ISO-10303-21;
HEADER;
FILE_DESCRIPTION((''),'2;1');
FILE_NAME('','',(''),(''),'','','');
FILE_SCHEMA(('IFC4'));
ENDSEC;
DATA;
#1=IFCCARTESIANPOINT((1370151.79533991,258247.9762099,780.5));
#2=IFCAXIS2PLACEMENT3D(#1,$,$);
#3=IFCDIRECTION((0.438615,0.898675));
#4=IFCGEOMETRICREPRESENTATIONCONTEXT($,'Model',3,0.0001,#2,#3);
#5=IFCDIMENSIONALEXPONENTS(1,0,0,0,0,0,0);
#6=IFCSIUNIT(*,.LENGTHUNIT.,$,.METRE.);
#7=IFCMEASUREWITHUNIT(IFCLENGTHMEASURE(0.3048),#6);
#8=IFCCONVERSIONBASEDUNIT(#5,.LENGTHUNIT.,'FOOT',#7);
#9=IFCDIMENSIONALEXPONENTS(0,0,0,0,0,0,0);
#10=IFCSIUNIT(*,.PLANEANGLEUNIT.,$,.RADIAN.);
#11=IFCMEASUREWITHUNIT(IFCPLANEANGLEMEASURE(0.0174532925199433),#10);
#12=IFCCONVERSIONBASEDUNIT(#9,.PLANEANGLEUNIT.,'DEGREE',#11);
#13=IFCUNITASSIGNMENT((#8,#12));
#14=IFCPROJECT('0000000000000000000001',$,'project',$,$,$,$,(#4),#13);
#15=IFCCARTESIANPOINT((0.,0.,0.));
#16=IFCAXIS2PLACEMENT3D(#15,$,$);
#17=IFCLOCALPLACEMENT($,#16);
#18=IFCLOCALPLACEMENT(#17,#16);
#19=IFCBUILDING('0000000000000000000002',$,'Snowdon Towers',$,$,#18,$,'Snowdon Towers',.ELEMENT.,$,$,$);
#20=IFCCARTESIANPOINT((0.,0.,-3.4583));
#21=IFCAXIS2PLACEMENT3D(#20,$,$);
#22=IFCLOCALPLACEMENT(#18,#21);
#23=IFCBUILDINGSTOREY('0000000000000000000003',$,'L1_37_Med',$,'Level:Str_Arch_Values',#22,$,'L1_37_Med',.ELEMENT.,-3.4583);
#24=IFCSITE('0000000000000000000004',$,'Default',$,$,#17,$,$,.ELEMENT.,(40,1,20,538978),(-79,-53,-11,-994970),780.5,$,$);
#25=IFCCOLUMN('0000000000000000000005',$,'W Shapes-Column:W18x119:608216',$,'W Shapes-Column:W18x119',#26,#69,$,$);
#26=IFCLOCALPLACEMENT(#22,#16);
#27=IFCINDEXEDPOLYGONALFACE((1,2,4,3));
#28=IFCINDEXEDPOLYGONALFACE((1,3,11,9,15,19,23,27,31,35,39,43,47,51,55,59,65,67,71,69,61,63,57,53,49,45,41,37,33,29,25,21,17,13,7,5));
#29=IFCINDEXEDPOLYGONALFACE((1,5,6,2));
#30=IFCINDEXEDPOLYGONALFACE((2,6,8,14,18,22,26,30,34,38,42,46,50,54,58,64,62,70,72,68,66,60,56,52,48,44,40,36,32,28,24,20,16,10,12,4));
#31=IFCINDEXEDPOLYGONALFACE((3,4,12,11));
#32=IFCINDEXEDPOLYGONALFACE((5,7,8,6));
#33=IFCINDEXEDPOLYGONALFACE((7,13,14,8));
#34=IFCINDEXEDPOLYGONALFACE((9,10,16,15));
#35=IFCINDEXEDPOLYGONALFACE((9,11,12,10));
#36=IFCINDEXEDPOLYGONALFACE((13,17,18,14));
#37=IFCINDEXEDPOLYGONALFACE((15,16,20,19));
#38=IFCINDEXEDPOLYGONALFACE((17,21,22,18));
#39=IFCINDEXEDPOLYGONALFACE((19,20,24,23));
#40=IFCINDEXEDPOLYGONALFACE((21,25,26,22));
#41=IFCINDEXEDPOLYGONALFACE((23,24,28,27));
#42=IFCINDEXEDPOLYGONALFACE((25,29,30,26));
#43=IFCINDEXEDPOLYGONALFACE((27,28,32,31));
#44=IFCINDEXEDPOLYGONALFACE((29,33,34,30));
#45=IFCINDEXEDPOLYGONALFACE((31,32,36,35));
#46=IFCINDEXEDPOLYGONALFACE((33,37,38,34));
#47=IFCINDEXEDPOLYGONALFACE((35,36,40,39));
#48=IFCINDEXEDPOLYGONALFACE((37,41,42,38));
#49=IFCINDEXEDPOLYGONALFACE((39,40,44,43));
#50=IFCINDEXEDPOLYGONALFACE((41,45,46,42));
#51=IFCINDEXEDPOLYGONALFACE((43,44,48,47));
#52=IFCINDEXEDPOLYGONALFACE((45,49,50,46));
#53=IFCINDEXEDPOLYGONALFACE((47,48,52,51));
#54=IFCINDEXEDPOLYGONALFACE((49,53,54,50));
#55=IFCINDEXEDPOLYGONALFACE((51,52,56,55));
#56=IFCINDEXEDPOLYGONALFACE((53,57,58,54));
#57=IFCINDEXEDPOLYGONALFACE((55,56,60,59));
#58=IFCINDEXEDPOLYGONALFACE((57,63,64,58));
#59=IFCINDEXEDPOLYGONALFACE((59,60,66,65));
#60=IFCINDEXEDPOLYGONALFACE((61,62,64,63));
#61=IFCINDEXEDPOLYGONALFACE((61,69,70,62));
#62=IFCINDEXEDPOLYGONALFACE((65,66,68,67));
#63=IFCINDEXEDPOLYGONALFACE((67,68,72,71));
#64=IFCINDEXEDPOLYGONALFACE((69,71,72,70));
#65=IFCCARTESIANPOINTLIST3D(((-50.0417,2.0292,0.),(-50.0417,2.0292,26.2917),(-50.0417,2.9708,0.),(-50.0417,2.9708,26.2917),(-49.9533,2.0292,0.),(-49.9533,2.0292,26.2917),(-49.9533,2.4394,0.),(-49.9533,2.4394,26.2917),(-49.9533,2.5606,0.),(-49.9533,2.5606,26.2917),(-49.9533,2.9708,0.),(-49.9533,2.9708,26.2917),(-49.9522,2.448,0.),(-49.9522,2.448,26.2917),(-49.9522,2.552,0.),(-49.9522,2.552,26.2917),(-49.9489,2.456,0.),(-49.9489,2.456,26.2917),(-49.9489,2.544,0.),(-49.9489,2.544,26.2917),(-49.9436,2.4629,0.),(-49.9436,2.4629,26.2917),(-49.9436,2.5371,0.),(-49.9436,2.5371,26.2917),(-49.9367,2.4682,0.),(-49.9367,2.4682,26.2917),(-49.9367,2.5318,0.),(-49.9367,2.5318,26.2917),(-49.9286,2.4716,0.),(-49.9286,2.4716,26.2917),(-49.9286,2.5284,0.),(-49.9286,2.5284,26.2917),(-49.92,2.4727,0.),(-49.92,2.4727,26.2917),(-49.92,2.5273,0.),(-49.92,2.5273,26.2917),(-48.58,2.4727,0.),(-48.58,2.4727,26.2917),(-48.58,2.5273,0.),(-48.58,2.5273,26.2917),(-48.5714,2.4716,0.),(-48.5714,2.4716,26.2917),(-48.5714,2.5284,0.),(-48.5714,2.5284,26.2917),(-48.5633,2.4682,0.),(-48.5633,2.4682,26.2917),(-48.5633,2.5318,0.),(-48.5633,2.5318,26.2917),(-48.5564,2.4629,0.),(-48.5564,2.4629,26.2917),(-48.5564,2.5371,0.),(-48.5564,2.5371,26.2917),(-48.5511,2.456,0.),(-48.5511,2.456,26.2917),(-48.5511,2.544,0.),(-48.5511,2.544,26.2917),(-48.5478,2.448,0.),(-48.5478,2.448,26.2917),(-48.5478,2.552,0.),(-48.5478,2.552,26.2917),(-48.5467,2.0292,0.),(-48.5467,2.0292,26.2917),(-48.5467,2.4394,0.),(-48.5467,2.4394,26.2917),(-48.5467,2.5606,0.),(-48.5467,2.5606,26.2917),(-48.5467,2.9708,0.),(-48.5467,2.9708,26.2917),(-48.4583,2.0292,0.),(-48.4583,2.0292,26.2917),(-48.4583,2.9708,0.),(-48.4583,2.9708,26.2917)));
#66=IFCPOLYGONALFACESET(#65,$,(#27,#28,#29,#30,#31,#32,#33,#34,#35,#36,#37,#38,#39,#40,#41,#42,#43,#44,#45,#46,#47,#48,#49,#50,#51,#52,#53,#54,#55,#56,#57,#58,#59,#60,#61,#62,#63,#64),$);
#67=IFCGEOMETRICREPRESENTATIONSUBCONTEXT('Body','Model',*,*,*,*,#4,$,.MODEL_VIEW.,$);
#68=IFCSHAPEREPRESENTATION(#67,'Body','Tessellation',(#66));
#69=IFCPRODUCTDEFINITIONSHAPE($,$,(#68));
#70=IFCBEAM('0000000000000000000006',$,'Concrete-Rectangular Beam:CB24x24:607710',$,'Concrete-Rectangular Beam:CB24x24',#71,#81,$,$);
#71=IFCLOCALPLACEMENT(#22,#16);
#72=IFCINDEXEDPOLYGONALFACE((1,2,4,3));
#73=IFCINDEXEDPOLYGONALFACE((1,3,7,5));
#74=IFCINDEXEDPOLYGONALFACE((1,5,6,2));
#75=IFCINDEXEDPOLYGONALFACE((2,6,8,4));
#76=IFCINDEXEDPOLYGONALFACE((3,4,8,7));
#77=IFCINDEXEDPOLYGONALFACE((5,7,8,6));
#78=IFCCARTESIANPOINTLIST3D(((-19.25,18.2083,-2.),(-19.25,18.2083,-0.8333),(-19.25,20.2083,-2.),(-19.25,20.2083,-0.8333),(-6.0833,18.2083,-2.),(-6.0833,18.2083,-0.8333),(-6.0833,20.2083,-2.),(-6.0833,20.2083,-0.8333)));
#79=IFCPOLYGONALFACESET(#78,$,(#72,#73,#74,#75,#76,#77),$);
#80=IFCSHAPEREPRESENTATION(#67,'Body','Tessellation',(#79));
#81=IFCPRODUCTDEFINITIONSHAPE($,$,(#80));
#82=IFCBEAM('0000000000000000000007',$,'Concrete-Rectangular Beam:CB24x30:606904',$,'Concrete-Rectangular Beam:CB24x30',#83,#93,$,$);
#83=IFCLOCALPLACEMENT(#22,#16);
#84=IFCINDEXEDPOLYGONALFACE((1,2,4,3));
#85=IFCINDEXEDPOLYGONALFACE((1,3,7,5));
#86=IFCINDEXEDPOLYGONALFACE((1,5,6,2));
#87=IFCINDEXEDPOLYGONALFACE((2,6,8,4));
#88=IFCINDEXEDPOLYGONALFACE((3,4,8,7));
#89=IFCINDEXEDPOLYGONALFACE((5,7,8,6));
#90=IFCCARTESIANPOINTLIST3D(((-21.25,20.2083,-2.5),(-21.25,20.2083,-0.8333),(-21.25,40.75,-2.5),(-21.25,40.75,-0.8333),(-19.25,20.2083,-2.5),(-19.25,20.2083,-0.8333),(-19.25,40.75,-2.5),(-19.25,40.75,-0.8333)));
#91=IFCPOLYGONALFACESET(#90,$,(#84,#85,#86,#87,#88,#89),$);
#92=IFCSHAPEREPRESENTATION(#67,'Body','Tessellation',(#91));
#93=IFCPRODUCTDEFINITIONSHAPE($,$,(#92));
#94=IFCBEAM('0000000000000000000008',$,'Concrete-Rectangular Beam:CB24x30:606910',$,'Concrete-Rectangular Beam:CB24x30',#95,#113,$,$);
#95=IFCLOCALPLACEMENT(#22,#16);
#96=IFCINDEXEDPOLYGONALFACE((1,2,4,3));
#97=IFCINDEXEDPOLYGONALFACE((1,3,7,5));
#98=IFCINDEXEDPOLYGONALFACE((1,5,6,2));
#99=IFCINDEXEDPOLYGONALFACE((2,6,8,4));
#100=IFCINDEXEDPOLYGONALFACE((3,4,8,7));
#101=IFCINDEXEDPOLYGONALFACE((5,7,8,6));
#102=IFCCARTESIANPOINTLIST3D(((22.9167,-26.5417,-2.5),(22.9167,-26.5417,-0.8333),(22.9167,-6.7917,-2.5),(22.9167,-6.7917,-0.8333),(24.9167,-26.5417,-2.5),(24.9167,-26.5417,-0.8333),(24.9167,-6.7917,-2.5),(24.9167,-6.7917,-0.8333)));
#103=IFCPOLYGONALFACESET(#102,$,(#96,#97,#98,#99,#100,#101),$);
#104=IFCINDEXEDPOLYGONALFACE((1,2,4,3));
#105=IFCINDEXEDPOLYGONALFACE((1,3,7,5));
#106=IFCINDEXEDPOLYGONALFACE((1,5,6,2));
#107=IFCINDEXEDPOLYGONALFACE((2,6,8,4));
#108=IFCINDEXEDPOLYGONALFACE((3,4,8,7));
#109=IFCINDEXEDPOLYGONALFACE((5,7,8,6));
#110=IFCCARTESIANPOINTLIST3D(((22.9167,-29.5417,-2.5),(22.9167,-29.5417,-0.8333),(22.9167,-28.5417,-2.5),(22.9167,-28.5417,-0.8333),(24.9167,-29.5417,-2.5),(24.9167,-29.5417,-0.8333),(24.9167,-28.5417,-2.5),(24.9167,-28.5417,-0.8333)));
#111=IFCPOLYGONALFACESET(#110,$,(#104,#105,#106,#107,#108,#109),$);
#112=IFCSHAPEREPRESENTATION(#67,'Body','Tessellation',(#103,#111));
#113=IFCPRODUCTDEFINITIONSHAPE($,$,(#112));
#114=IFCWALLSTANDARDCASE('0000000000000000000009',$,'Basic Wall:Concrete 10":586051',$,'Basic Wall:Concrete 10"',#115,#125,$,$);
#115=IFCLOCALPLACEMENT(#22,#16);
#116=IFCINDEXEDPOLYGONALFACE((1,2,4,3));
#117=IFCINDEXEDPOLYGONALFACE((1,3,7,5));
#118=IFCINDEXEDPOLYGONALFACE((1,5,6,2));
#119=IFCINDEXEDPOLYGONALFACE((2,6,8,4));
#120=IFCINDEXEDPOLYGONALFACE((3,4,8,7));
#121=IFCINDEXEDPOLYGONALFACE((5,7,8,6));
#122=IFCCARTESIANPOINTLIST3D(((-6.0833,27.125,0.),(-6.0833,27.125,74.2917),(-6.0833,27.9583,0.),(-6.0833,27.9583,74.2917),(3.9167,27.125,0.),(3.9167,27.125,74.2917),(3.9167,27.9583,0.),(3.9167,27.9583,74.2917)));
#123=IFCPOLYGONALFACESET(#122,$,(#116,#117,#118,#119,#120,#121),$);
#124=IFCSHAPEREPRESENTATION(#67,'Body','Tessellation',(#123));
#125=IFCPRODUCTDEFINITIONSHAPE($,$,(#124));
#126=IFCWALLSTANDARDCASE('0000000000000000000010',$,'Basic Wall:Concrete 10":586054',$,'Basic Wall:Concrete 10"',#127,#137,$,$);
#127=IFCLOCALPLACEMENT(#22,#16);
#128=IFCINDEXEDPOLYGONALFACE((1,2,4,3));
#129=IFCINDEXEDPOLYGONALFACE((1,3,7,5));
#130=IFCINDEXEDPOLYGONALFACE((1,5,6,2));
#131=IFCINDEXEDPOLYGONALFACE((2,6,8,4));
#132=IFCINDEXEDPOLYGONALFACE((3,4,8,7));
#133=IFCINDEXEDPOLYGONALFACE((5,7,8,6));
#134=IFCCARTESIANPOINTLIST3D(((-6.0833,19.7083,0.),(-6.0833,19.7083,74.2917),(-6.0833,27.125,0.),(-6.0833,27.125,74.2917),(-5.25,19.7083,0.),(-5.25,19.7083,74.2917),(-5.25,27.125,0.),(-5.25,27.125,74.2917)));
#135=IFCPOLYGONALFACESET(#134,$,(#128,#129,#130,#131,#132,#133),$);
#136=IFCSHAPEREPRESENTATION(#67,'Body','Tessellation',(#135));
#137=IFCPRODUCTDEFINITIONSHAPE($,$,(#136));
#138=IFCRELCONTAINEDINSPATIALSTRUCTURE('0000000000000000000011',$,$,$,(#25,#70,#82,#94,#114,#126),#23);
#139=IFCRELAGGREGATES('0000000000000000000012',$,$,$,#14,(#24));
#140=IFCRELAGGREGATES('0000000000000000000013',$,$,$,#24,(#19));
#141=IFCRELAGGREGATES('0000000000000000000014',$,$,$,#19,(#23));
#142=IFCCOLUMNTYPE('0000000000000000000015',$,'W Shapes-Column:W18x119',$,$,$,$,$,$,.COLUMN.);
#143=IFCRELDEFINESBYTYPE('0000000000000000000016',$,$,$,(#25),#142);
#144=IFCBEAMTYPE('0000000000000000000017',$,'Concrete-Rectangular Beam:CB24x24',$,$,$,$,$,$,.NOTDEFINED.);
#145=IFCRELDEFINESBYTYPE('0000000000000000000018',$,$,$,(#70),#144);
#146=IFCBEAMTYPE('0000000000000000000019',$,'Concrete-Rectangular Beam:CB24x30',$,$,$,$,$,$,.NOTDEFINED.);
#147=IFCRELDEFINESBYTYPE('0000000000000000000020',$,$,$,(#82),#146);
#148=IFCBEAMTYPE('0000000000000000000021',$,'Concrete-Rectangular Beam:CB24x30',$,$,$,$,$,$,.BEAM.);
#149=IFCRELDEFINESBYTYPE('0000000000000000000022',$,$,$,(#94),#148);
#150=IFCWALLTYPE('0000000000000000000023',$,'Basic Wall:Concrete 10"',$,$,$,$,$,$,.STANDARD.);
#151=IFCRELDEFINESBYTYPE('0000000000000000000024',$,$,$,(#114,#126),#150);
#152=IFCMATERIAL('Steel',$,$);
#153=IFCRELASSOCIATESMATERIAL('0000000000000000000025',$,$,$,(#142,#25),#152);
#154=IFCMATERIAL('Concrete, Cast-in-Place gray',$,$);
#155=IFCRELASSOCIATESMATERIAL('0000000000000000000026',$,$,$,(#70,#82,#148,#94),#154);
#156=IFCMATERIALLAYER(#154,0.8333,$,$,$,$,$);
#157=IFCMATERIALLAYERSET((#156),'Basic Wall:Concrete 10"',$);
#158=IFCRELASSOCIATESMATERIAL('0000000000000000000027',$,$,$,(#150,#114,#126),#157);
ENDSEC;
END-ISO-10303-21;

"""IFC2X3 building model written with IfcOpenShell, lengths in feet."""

from ifc_helpers import new_model, entity, si_unit, converted_unit, direction, frame, frame_2d, origin, place, context, subcontext, project, spatial, rectangle, i_section, extrude, source, transform, mapped, material, layer, layer_set, layer_usage, type_object, type_shapes, element, save


model = new_model("IFC2X3")

# Units and contexts
model_context = context("Model", 3, precision=0.0001, world=frame((1370151.79533991, 258247.9762099, 780.5)), true_north=direction((0.438615, 0.898675)))
body_context = subcontext(model_context, "Body", "Model", "MODEL_VIEW")
ifc_project = project(units=[converted_unit("LENGTHUNIT", "FOOT", entity("IfcLengthMeasure", 0.3048), si_unit("LENGTHUNIT", "METRE"), dimensions=[1, 0, 0, 0, 0, 0, 0]), converted_unit("PLANEANGLEUNIT", "DEGREE", entity("IfcPlaneAngleMeasure", 0.0174532925199433), si_unit("PLANEANGLEUNIT", "RADIAN"), dimensions=[0, 0, 0, 0, 0, 0, 0])], contexts=[model_context])

# Site, building, storey
site_placement = place(None, origin())
site = spatial("IfcSite", under=ifc_project, at=site_placement, Name="Default", CompositionType="ELEMENT", RefLatitude=(40, 1, 20, 538978), RefLongitude=(-79, -53, -11, -994970), RefElevation=780.5)
building_placement = place(site_placement, origin())
building = spatial("IfcBuilding", under=site, at=building_placement, Name="Snowdon Towers", LongName="Snowdon Towers", CompositionType="ELEMENT")
storey_placement = place(building_placement, frame((0.0, 0.0, -3.4583)))
storey = spatial("IfcBuildingStorey", under=building, at=storey_placement, Name="L1_37_Med", ObjectType="Level:Str_Arch_Values", LongName="L1_37_Med", CompositionType="ELEMENT", Elevation=-3.4583)

# Column
ifc_material_1 = material(Name="Steel")
column_type_1 = type_object("IfcColumnType", Name="W Shapes-Column:W18x119", PredefinedType="COLUMN", material=ifc_material_1)
shared_shape_1 = source(origin(), body_context, "Body", "SweptSolid", [
    extrude(i_section(OverallWidth=0.9417, OverallDepth=1.5833, WebThickness=0.0546, FlangeThickness=0.0883, FilletRadius=0.0333, at=frame_2d((0.0, 0.0), x_axis=(1.0, 0.0))), frame((0.0, 0.0, -3.4583), z_axis=(0.0, 0.0, 1.0), x_axis=(-1.0, 0.0, 0.0)), (0.0, 0.0, 1.0), 26.2917),
])
type_shapes(column_type_1, [shared_shape_1])
column_1_placement = place(storey_placement, frame((-49.25, 2.5, 3.4583), z_axis=(0.0, 0.0, 1.0), x_axis=(0.0, -1.0, 0.0)))
element("IfcColumn", 1, at=column_1_placement, inside=storey, type_object=column_type_1, material=ifc_material_1, Name="W Shapes-Column:W18x119:608216", ObjectType="W Shapes-Column:W18x119", context=body_context, shape_type="MappedRepresentation", body=[
    mapped(shared_shape_1, transform((0.0, 0.0, 0.0), scale=1.0)),
])

# Beams
ifc_material_2 = material(Name="Concrete, Cast-in-Place gray")
beam_type_1 = type_object("IfcBeamType", Name="Concrete-Rectangular Beam:CB24x24", PredefinedType="NOTDEFINED")
beam_1_placement = place(storey_placement, frame((-20.25, 19.2083, 0.0)))
element("IfcBeam", 2, at=beam_1_placement, inside=storey, type_object=beam_type_1, material=ifc_material_2, Name="Concrete-Rectangular Beam:CB24x24:607710", ObjectType="Concrete-Rectangular Beam:CB24x24", context=body_context, shape_type="SweptSolid", body=[
    extrude(rectangle(XDim=1.1667, YDim=2.0, at=frame_2d((0.0, 0.0), x_axis=(1.0, 0.0))), frame((1.0, 0.0, -1.4167), z_axis=(1.0, 0.0, 0.0), x_axis=(0.0, 0.0, -1.0)), (0.0, 0.0, 1.0), 13.1667),
])
beam_type_2 = type_object("IfcBeamType", Name="Concrete-Rectangular Beam:CB24x30", PredefinedType="NOTDEFINED")
beam_2_placement = place(storey_placement, frame((-20.25, 19.2083, 0.0), z_axis=(0.0, 0.0, 1.0), x_axis=(0.0, 1.0, 0.0)))
element("IfcBeam", 3, at=beam_2_placement, inside=storey, type_object=beam_type_2, material=ifc_material_2, Name="Concrete-Rectangular Beam:CB24x30:606904", ObjectType="Concrete-Rectangular Beam:CB24x30", context=body_context, shape_type="SweptSolid", body=[
    extrude(rectangle(XDim=1.6667, YDim=2.0, at=frame_2d((0.0, 0.0), x_axis=(1.0, 0.0))), frame((1.0, 0.0, -1.6667), z_axis=(1.0, 0.0, 0.0), x_axis=(0.0, 0.0, -1.0)), (0.0, 0.0, 1.0), 20.5417),
])
beam_type_3 = type_object("IfcBeamType", Name="Concrete-Rectangular Beam:CB24x30", PredefinedType="BEAM", material=ifc_material_2)
shared_shape_2 = source(origin(), body_context, "Body", "SweptSolid", [
    extrude(rectangle(XDim=1.6667, YDim=2.0, at=frame_2d((0.0, 0.0), x_axis=(0.0, 1.0))), frame((23.9167, -26.5417, -5.125), z_axis=(0.0, 1.0, 0.0), x_axis=(-1.0, 0.0, 0.0)), (0.0, 0.0, 1.0), 19.75),
    extrude(rectangle(XDim=1.6667, YDim=2.0, at=frame_2d((0.0, 0.0), x_axis=(0.0, 1.0))), frame((23.9167, -29.5417, -5.125), z_axis=(0.0, 1.0, 0.0), x_axis=(-1.0, 0.0, 0.0)), (0.0, 0.0, 1.0), 1.0),
])
type_shapes(beam_type_3, [shared_shape_2])
beam_3_placement = place(storey_placement, frame((0.0, 0.0, 3.4583)))
element("IfcBeam", 4, at=beam_3_placement, inside=storey, type_object=beam_type_3, material=ifc_material_2, Name="Concrete-Rectangular Beam:CB24x30:606910", ObjectType="Concrete-Rectangular Beam:CB24x30", context=body_context, shape_type="MappedRepresentation", body=[
    mapped(shared_shape_2, transform((0.0, 0.0, 0.0), scale=1.0)),
])

# Walls
ifc_layer_1 = layer(ifc_material_2, 0.8333)
ifc_layer_set_1 = layer_set([ifc_layer_1], Name="Basic Wall:Concrete 10\"")
ifc_layer_usage_1 = layer_usage(ifc_layer_set_1, "AXIS2", "POSITIVE", -0.4167)
wall_type_1 = type_object("IfcWallType", Name="Basic Wall:Concrete 10\"", PredefinedType="STANDARD", material=ifc_layer_set_1)
wall_1_placement = place(storey_placement, frame((-6.0833, 27.5417, 0.0)))
element("IfcWallStandardCase", 5, at=wall_1_placement, inside=storey, type_object=wall_type_1, material=ifc_layer_usage_1, Name="Basic Wall:Concrete 10\":586051", ObjectType="Basic Wall:Concrete 10\"", context=body_context, shape_type="SweptSolid", body=[
    extrude(rectangle(XDim=10.0, YDim=0.8333, at=frame_2d((5.0, 0.0), x_axis=(-1.0, 0.0))), origin(), (0.0, 0.0, 1.0), 74.2917),
])
ifc_layer_usage_2 = layer_usage(ifc_layer_set_1, "AXIS2", "POSITIVE", -0.4167)
wall_2_placement = place(storey_placement, frame((-5.6667, 19.7083, 0.0), z_axis=(0.0, 0.0, 1.0), x_axis=(0.0, 1.0, 0.0)))
element("IfcWallStandardCase", 6, at=wall_2_placement, inside=storey, type_object=wall_type_1, material=ifc_layer_usage_2, Name="Basic Wall:Concrete 10\":586054", ObjectType="Basic Wall:Concrete 10\"", context=body_context, shape_type="SweptSolid", body=[
    extrude(rectangle(XDim=7.4167, YDim=0.8333, at=frame_2d((3.7083, 0.0), x_axis=(-1.0, 0.0))), origin(), (0.0, 0.0, 1.0), 74.2917),
])

save(model, "model.ifc")
